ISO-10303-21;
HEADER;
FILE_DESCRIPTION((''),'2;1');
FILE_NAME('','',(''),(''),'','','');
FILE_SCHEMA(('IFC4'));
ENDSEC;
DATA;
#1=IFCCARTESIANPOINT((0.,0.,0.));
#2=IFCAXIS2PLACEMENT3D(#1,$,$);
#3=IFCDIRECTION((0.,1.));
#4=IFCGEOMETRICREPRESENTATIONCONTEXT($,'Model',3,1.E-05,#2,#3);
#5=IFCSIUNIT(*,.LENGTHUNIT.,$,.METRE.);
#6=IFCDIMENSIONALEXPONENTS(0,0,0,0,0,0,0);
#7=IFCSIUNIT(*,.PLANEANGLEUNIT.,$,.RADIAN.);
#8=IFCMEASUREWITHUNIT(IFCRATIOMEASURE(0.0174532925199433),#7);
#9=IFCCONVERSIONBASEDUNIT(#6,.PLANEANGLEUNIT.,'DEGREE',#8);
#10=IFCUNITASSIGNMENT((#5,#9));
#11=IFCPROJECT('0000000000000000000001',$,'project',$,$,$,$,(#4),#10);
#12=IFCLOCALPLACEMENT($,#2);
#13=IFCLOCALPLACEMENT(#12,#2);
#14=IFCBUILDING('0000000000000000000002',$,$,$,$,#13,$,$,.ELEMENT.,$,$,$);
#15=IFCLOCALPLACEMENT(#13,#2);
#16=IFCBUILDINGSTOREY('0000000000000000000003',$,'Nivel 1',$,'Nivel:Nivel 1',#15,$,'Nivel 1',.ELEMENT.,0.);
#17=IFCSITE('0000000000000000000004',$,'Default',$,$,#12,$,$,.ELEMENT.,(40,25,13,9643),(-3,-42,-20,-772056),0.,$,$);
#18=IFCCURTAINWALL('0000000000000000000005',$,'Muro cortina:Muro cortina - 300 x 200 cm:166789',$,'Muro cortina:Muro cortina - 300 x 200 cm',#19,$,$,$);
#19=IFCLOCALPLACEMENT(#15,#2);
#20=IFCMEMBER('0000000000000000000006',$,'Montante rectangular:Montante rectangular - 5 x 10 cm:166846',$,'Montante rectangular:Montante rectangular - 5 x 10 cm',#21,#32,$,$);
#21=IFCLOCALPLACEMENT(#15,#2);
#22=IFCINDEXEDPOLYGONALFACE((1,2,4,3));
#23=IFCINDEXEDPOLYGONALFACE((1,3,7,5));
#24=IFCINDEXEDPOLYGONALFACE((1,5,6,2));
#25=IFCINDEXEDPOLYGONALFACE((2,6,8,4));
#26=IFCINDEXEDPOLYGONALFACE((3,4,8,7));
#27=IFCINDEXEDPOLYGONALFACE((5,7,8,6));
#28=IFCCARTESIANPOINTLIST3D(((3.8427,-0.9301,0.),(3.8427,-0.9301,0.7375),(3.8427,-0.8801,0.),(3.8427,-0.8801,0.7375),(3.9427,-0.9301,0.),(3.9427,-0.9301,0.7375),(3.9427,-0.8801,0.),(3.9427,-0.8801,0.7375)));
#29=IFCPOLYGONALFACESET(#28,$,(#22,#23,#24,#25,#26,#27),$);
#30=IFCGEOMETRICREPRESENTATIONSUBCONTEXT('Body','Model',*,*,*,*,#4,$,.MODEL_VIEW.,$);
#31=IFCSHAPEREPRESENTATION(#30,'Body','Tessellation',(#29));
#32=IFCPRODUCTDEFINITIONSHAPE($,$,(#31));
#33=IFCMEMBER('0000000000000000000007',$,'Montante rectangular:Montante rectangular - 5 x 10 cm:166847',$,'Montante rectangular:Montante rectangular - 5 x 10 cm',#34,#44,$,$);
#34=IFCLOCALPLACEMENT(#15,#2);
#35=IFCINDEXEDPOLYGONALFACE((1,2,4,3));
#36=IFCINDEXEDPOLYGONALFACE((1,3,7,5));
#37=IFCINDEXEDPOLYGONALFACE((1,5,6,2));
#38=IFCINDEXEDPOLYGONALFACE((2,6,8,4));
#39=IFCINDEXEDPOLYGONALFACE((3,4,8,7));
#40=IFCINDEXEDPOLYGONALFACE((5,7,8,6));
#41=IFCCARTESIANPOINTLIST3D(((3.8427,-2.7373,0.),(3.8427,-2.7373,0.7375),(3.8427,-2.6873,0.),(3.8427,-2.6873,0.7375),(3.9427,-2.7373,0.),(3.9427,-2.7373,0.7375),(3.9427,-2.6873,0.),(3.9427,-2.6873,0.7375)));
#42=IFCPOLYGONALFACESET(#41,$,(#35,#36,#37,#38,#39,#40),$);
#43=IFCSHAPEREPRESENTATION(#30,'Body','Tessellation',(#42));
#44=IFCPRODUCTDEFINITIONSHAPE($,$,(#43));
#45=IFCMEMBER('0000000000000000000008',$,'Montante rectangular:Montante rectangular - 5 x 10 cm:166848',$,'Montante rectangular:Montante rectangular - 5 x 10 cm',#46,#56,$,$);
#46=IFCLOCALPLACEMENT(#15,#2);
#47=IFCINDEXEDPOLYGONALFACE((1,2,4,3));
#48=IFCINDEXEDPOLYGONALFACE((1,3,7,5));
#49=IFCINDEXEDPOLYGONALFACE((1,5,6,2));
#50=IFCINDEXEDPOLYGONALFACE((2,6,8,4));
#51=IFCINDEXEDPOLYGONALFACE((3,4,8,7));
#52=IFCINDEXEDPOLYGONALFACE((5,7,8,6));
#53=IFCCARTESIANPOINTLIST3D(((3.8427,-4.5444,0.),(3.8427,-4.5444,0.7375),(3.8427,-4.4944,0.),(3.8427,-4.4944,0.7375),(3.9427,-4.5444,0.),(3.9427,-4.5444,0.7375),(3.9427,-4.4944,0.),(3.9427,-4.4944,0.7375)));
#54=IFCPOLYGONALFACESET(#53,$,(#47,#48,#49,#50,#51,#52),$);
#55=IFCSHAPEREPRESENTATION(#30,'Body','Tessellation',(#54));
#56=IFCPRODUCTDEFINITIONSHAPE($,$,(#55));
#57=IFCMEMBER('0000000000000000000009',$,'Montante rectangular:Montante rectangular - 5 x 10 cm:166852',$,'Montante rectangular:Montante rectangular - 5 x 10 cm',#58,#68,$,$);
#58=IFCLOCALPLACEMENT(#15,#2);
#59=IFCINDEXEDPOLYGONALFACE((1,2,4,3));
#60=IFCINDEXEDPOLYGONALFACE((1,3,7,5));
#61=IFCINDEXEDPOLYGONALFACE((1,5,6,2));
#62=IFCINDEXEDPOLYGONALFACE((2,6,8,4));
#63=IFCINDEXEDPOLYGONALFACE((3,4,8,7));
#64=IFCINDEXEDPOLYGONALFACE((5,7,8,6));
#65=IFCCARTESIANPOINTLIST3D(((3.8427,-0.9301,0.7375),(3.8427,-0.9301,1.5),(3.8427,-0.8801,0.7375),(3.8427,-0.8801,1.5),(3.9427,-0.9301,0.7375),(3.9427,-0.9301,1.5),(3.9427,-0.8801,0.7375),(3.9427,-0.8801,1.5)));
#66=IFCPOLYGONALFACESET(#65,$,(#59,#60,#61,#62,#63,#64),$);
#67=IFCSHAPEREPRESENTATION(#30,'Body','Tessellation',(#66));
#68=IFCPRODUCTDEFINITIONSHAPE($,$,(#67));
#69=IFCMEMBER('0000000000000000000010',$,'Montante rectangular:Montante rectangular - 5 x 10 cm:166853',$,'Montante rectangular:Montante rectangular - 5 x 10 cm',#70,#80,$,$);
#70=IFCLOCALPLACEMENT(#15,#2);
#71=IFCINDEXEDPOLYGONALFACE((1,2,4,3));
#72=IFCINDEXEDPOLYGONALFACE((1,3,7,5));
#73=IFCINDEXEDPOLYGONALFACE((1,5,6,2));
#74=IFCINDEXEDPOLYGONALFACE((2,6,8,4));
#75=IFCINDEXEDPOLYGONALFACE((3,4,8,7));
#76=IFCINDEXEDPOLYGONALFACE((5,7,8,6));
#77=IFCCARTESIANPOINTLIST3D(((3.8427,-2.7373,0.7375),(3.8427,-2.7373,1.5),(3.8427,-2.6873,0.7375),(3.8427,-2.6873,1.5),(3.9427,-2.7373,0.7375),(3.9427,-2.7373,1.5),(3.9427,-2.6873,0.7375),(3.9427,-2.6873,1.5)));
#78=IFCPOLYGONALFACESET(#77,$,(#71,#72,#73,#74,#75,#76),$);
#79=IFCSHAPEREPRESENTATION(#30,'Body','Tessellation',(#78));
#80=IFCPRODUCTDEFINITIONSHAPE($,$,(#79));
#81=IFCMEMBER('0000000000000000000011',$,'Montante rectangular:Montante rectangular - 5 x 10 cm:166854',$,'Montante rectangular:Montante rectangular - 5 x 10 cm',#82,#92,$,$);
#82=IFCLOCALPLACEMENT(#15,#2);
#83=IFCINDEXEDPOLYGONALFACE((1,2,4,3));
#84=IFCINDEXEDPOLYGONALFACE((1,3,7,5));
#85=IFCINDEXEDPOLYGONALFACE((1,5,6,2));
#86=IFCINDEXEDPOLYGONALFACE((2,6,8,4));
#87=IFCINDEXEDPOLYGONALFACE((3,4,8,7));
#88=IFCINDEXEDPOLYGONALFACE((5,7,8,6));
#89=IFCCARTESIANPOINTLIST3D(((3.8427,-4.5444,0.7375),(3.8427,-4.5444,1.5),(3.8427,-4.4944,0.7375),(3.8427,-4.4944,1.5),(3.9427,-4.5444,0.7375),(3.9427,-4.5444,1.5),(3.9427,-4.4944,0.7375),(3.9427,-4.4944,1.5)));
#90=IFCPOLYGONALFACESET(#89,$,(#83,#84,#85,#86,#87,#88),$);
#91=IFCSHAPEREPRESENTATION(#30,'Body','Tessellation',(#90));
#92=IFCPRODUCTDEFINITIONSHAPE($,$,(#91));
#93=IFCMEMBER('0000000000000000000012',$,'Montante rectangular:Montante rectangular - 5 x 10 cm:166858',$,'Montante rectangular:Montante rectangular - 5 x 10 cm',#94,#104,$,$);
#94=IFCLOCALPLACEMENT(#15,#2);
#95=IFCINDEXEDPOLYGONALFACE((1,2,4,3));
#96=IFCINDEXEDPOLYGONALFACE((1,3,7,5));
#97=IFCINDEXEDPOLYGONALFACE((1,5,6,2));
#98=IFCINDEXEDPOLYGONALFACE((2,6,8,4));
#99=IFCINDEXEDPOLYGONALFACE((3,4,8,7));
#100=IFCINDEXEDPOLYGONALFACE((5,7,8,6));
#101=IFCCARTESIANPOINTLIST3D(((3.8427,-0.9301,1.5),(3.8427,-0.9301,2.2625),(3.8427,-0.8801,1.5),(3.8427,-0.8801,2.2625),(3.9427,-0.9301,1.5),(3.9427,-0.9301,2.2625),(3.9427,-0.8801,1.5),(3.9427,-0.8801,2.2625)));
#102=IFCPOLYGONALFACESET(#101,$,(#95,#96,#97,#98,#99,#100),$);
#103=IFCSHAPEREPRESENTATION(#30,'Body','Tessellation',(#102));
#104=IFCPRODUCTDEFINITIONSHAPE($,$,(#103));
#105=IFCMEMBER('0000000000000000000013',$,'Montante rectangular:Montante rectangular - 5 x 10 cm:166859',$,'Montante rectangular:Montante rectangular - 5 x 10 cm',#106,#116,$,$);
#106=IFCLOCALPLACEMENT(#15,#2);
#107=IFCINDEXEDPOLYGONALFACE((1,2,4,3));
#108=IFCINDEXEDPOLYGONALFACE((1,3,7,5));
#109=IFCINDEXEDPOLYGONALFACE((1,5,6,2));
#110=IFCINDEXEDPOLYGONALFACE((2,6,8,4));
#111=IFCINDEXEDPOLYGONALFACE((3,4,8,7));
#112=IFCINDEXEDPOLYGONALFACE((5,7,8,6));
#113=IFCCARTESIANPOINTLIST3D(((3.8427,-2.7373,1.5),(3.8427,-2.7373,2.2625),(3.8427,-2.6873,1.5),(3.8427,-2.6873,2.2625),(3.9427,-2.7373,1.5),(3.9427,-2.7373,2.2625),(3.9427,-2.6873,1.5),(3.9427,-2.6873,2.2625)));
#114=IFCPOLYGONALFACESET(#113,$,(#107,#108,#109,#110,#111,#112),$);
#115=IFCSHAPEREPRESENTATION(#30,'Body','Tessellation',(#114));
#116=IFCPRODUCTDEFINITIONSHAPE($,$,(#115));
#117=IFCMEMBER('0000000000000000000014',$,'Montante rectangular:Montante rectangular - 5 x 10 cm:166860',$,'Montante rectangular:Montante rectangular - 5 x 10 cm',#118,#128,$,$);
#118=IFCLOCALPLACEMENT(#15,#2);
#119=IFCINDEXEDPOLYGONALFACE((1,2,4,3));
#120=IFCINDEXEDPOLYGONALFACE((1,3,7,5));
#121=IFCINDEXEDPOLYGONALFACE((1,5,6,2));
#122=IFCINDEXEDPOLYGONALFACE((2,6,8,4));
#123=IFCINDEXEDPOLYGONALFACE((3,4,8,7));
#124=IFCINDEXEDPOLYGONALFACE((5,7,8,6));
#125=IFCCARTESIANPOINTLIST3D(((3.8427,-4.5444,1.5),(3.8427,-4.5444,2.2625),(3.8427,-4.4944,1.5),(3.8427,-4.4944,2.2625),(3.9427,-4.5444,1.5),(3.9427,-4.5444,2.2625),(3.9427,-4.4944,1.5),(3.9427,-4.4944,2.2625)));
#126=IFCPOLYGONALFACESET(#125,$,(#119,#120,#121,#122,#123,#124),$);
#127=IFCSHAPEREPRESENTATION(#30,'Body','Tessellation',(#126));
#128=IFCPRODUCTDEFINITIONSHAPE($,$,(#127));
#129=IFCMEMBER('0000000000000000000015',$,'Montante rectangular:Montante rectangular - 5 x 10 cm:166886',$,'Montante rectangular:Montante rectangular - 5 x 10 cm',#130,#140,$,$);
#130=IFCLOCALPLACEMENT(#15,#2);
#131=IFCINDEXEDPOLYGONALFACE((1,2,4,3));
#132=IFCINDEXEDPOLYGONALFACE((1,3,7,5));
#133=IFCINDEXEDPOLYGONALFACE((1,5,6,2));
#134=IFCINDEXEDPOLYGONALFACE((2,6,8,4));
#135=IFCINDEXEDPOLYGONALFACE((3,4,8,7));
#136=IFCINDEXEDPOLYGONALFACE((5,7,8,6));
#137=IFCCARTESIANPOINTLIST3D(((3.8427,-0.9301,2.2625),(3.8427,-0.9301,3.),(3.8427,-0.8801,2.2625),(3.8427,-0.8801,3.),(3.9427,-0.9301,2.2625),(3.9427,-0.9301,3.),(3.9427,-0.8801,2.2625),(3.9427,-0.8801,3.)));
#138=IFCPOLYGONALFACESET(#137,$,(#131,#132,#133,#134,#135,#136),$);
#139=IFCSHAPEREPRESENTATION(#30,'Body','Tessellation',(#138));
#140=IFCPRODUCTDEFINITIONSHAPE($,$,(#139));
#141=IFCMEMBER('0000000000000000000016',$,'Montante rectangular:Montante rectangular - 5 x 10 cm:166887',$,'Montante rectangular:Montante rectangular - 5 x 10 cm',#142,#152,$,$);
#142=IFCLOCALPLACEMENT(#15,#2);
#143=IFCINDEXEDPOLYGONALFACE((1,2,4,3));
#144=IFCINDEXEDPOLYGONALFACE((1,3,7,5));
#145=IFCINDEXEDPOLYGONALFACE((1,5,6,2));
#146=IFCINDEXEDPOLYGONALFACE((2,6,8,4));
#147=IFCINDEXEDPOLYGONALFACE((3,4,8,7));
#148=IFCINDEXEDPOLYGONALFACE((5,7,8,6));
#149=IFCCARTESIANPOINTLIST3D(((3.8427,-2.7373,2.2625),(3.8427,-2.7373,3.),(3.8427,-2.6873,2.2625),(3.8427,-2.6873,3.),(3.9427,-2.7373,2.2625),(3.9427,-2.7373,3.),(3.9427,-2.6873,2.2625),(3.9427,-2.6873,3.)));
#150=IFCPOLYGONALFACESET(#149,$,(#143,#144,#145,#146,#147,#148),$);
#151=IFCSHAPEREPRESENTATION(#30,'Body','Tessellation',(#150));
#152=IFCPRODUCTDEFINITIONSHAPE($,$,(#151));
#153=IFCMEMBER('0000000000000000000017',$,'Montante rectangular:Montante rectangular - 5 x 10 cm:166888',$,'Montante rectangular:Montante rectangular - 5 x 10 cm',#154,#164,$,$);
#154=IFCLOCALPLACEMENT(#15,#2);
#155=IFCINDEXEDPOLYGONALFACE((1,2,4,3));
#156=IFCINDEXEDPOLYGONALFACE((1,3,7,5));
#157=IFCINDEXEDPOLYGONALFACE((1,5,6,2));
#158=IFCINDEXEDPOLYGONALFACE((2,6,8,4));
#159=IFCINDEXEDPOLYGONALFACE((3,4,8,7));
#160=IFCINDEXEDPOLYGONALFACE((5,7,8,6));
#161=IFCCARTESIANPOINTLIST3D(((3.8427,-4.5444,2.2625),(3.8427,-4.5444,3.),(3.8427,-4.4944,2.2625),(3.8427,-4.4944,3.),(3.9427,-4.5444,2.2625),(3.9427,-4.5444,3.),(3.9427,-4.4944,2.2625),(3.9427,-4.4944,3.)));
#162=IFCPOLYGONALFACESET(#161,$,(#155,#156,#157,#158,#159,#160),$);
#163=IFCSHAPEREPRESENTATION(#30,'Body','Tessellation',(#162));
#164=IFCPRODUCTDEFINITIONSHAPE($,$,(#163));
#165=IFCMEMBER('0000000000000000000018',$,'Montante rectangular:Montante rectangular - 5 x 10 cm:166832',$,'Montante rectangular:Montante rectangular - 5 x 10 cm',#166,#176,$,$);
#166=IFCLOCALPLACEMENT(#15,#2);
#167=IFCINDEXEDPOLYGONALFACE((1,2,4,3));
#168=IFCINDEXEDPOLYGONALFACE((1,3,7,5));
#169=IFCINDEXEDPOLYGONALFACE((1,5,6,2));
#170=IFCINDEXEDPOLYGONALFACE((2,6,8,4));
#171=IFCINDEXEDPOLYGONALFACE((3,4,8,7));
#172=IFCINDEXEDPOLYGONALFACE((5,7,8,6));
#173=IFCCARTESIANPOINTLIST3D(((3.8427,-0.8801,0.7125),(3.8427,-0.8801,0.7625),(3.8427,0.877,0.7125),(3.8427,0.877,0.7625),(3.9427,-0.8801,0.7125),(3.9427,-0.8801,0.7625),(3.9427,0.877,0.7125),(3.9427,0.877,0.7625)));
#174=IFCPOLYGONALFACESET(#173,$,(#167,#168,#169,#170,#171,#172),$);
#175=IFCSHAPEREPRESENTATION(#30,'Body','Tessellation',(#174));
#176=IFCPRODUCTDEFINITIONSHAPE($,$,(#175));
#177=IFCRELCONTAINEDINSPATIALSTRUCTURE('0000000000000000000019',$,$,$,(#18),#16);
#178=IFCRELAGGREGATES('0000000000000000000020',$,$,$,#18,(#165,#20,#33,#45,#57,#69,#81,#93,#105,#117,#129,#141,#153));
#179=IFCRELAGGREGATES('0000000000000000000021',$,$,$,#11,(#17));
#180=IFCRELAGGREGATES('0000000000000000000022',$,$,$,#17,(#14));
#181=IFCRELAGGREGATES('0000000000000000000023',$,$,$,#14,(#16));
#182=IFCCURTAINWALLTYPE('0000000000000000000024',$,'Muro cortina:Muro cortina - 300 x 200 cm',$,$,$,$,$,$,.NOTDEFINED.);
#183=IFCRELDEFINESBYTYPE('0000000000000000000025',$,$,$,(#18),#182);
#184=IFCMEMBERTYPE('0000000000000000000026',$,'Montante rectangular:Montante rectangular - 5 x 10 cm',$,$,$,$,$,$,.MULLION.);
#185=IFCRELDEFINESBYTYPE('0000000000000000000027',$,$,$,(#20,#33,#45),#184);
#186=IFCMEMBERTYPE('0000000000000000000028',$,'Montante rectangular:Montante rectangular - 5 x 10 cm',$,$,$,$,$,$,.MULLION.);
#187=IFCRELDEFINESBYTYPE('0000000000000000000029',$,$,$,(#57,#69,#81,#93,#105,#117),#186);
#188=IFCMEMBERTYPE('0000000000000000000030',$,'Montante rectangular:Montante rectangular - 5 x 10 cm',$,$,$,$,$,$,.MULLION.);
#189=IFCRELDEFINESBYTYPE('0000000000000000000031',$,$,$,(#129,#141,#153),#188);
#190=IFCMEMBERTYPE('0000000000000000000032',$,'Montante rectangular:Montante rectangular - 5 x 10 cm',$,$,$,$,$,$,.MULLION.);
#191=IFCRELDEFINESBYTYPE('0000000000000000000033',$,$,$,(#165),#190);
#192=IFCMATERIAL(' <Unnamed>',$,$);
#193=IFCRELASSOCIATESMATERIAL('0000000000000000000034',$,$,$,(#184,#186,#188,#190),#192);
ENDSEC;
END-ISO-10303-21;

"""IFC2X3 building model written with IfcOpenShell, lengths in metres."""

from ifc_helpers import new_model, entity, si_unit, converted_unit, direction, frame, origin, origin_2d_with_axis, place, context, subcontext, project, spatial, rectangle, extrude, source, transform, mapped, material, type_object, type_shapes, element, aggregate, save


model = new_model("IFC2X3")

# Units and contexts
model_context = context("Model", 3, precision=1e-05, world=origin(), true_north=direction((0.0, 1.0)))
body_context = subcontext(model_context, "Body", "Model", "MODEL_VIEW")
ifc_project = project(units=[si_unit("LENGTHUNIT", "METRE"), converted_unit("PLANEANGLEUNIT", "DEGREE", entity("IfcRatioMeasure", 0.0174532925199433), si_unit("PLANEANGLEUNIT", "RADIAN"), dimensions=[0, 0, 0, 0, 0, 0, 0])], contexts=[model_context])

# Site, building, storey
site_placement = place(None, origin())
site = spatial("IfcSite", under=ifc_project, at=site_placement, Name="Default", CompositionType="ELEMENT", RefLatitude=(40, 25, 13, 9643), RefLongitude=(-3, -42, -20, -772056), RefElevation=0.0)
building_placement = place(site_placement, origin())
building = spatial("IfcBuilding", under=site, at=building_placement, CompositionType="ELEMENT")
storey_placement = place(building_placement, origin())
storey = spatial("IfcBuildingStorey", under=building, at=storey_placement, Name="Nivel 1", ObjectType="Nivel:Nivel 1", LongName="Nivel 1", CompositionType="ELEMENT", Elevation=0.0)

# Curtain wall, members
curtain_wall_type = type_object("IfcCurtainWallType", Name="Muro cortina:Muro cortina - 300 x 200 cm", PredefinedType="NOTDEFINED")
curtain_wall_placement = place(storey_placement, origin())
curtain_wall = element("IfcCurtainWall", 1, at=curtain_wall_placement, inside=storey, type_object=curtain_wall_type, Name="Muro cortina:Muro cortina - 300 x 200 cm:166789", ObjectType="Muro cortina:Muro cortina - 300 x 200 cm")
ifc_material_1 = material(Name=" <Unnamed>")
member_type_1 = type_object("IfcMemberType", Name="Montante rectangular:Montante rectangular - 5 x 10 cm", PredefinedType="MULLION", material=ifc_material_1)
shared_shape_1 = source(origin(), body_context, "Body", "SweptSolid", [
    extrude(rectangle(XDim=0.1, YDim=0.05, at=origin_2d_with_axis()), frame((0.0, 0.0, -0.7375), z_axis=(0.0, 0.0, 1.0), x_axis=(0.0, -1.0, 0.0)), (0.0, 0.0, 1.0), 0.7375),
])
type_shapes(member_type_1, [shared_shape_1])
member_1_placement = place(storey_placement, frame((3.8927, -0.9051, 0.0), z_axis=(0.0, 0.0, -1.0), x_axis=(0.0, -1.0, 0.0)))
member_1 = element("IfcMember", 2, at=member_1_placement, type_object=member_type_1, Name="Montante rectangular:Montante rectangular - 5 x 10 cm:166846", ObjectType="Montante rectangular:Montante rectangular - 5 x 10 cm", context=body_context, shape_type="MappedRepresentation", body=[
    mapped(shared_shape_1, transform((0.0, 0.0, 0.0), scale=1.0)),
])
member_2_placement = place(storey_placement, frame((3.8927, -2.7123, 0.0), z_axis=(0.0, 0.0, -1.0), x_axis=(0.0, -1.0, 0.0)))
member_2 = element("IfcMember", 3, at=member_2_placement, type_object=member_type_1, Name="Montante rectangular:Montante rectangular - 5 x 10 cm:166847", ObjectType="Montante rectangular:Montante rectangular - 5 x 10 cm", context=body_context, shape_type="MappedRepresentation", body=[
    mapped(shared_shape_1, transform((0.0, 0.0, 0.0), scale=1.0)),
])
member_3_placement = place(storey_placement, frame((3.8927, -4.5194, 0.0), z_axis=(0.0, 0.0, -1.0), x_axis=(0.0, -1.0, 0.0)))
member_3 = element("IfcMember", 4, at=member_3_placement, type_object=member_type_1, Name="Montante rectangular:Montante rectangular - 5 x 10 cm:166848", ObjectType="Montante rectangular:Montante rectangular - 5 x 10 cm", context=body_context, shape_type="MappedRepresentation", body=[
    mapped(shared_shape_1, transform((0.0, 0.0, 0.0), scale=1.0)),
])
member_type_2 = type_object("IfcMemberType", Name="Montante rectangular:Montante rectangular - 5 x 10 cm", PredefinedType="MULLION", material=ifc_material_1)
shared_shape_2 = source(origin(), body_context, "Body", "SweptSolid", [
    extrude(rectangle(XDim=0.1, YDim=0.05, at=origin_2d_with_axis()), frame((0.0, 0.0, -0.7625), z_axis=(0.0, 0.0, 1.0), x_axis=(0.0, -1.0, 0.0)), (0.0, 0.0, 1.0), 0.7625),
])
type_shapes(member_type_2, [shared_shape_2])
member_4_placement = place(storey_placement, frame((3.8927, -0.9051, 0.7375), z_axis=(0.0, 0.0, -1.0), x_axis=(0.0, -1.0, 0.0)))
member_4 = element("IfcMember", 5, at=member_4_placement, type_object=member_type_2, Name="Montante rectangular:Montante rectangular - 5 x 10 cm:166852", ObjectType="Montante rectangular:Montante rectangular - 5 x 10 cm", context=body_context, shape_type="MappedRepresentation", body=[
    mapped(shared_shape_2, transform((0.0, 0.0, 0.0), scale=1.0)),
])
member_5_placement = place(storey_placement, frame((3.8927, -2.7123, 0.7375), z_axis=(0.0, 0.0, -1.0), x_axis=(0.0, -1.0, 0.0)))
member_5 = element("IfcMember", 6, at=member_5_placement, type_object=member_type_2, Name="Montante rectangular:Montante rectangular - 5 x 10 cm:166853", ObjectType="Montante rectangular:Montante rectangular - 5 x 10 cm", context=body_context, shape_type="MappedRepresentation", body=[
    mapped(shared_shape_2, transform((0.0, 0.0, 0.0), scale=1.0)),
])
member_6_placement = place(storey_placement, frame((3.8927, -4.5194, 0.7375), z_axis=(0.0, 0.0, -1.0), x_axis=(0.0, -1.0, 0.0)))
member_6 = element("IfcMember", 7, at=member_6_placement, type_object=member_type_2, Name="Montante rectangular:Montante rectangular - 5 x 10 cm:166854", ObjectType="Montante rectangular:Montante rectangular - 5 x 10 cm", context=body_context, shape_type="MappedRepresentation", body=[
    mapped(shared_shape_2, transform((0.0, 0.0, 0.0), scale=1.0)),
])
member_7_placement = place(storey_placement, frame((3.8927, -0.9051, 1.5), z_axis=(0.0, 0.0, -1.0), x_axis=(0.0, -1.0, 0.0)))
member_7 = element("IfcMember", 8, at=member_7_placement, type_object=member_type_2, Name="Montante rectangular:Montante rectangular - 5 x 10 cm:166858", ObjectType="Montante rectangular:Montante rectangular - 5 x 10 cm", context=body_context, shape_type="MappedRepresentation", body=[
    mapped(shared_shape_2, transform((0.0, 0.0, 0.0), scale=1.0)),
])
member_8_placement = place(storey_placement, frame((3.8927, -2.7123, 1.5), z_axis=(0.0, 0.0, -1.0), x_axis=(0.0, -1.0, 0.0)))
member_8 = element("IfcMember", 9, at=member_8_placement, type_object=member_type_2, Name="Montante rectangular:Montante rectangular - 5 x 10 cm:166859", ObjectType="Montante rectangular:Montante rectangular - 5 x 10 cm", context=body_context, shape_type="MappedRepresentation", body=[
    mapped(shared_shape_2, transform((0.0, 0.0, 0.0), scale=1.0)),
])
member_9_placement = place(storey_placement, frame((3.8927, -4.5194, 1.5), z_axis=(0.0, 0.0, -1.0), x_axis=(0.0, -1.0, 0.0)))
member_9 = element("IfcMember", 10, at=member_9_placement, type_object=member_type_2, Name="Montante rectangular:Montante rectangular - 5 x 10 cm:166860", ObjectType="Montante rectangular:Montante rectangular - 5 x 10 cm", context=body_context, shape_type="MappedRepresentation", body=[
    mapped(shared_shape_2, transform((0.0, 0.0, 0.0), scale=1.0)),
])
member_type_3 = type_object("IfcMemberType", Name="Montante rectangular:Montante rectangular - 5 x 10 cm", PredefinedType="MULLION", material=ifc_material_1)
shared_shape_3 = source(origin(), body_context, "Body", "SweptSolid", [
    extrude(rectangle(XDim=0.1, YDim=0.05, at=origin_2d_with_axis()), frame((0.0, 0.0, -0.7375), z_axis=(0.0, 0.0, 1.0), x_axis=(0.0, -1.0, 0.0)), (0.0, 0.0, 1.0), 0.7375),
])
type_shapes(member_type_3, [shared_shape_3])
member_10_placement = place(storey_placement, frame((3.8927, -0.9051, 2.2625), z_axis=(0.0, 0.0, -1.0), x_axis=(0.0, -1.0, 0.0)))
member_10 = element("IfcMember", 11, at=member_10_placement, type_object=member_type_3, Name="Montante rectangular:Montante rectangular - 5 x 10 cm:166886", ObjectType="Montante rectangular:Montante rectangular - 5 x 10 cm", context=body_context, shape_type="MappedRepresentation", body=[
    mapped(shared_shape_3, transform((0.0, 0.0, 0.0), scale=1.0)),
])
member_11_placement = place(storey_placement, frame((3.8927, -2.7123, 2.2625), z_axis=(0.0, 0.0, -1.0), x_axis=(0.0, -1.0, 0.0)))
member_11 = element("IfcMember", 12, at=member_11_placement, type_object=member_type_3, Name="Montante rectangular:Montante rectangular - 5 x 10 cm:166887", ObjectType="Montante rectangular:Montante rectangular - 5 x 10 cm", context=body_context, shape_type="MappedRepresentation", body=[
    mapped(shared_shape_3, transform((0.0, 0.0, 0.0), scale=1.0)),
])
member_12_placement = place(storey_placement, frame((3.8927, -4.5194, 2.2625), z_axis=(0.0, 0.0, -1.0), x_axis=(0.0, -1.0, 0.0)))
member_12 = element("IfcMember", 13, at=member_12_placement, type_object=member_type_3, Name="Montante rectangular:Montante rectangular - 5 x 10 cm:166888", ObjectType="Montante rectangular:Montante rectangular - 5 x 10 cm", context=body_context, shape_type="MappedRepresentation", body=[
    mapped(shared_shape_3, transform((0.0, 0.0, 0.0), scale=1.0)),
])
member_type_4 = type_object("IfcMemberType", Name="Montante rectangular:Montante rectangular - 5 x 10 cm", PredefinedType="MULLION", material=ifc_material_1)
shared_shape_4 = source(origin(), body_context, "Body", "SweptSolid", [
    extrude(rectangle(XDim=0.1, YDim=0.05, at=origin_2d_with_axis()), frame((0.0, 0.0, -1.7571), z_axis=(0.0, 0.0, 1.0), x_axis=(0.0, -1.0, 0.0)), (0.0, 0.0, 1.0), 1.7571),
])
type_shapes(member_type_4, [shared_shape_4])
member_13_placement = place(storey_placement, frame((3.8927, -0.8801, 0.7375), z_axis=(0.0, -1.0, 0.0), x_axis=(0.0, 0.0, 1.0)))
member_13 = element("IfcMember", 14, at=member_13_placement, type_object=member_type_4, Name="Montante rectangular:Montante rectangular - 5 x 10 cm:166832", ObjectType="Montante rectangular:Montante rectangular - 5 x 10 cm", context=body_context, shape_type="MappedRepresentation", body=[
    mapped(shared_shape_4, transform((0.0, 0.0, 0.0), scale=1.0)),
])
aggregate(curtain_wall, [member_13, member_1, member_2, member_3, member_4, member_5, member_6, member_7, member_8, member_9, member_10, member_11, member_12])

save(model, "model.ifc")
